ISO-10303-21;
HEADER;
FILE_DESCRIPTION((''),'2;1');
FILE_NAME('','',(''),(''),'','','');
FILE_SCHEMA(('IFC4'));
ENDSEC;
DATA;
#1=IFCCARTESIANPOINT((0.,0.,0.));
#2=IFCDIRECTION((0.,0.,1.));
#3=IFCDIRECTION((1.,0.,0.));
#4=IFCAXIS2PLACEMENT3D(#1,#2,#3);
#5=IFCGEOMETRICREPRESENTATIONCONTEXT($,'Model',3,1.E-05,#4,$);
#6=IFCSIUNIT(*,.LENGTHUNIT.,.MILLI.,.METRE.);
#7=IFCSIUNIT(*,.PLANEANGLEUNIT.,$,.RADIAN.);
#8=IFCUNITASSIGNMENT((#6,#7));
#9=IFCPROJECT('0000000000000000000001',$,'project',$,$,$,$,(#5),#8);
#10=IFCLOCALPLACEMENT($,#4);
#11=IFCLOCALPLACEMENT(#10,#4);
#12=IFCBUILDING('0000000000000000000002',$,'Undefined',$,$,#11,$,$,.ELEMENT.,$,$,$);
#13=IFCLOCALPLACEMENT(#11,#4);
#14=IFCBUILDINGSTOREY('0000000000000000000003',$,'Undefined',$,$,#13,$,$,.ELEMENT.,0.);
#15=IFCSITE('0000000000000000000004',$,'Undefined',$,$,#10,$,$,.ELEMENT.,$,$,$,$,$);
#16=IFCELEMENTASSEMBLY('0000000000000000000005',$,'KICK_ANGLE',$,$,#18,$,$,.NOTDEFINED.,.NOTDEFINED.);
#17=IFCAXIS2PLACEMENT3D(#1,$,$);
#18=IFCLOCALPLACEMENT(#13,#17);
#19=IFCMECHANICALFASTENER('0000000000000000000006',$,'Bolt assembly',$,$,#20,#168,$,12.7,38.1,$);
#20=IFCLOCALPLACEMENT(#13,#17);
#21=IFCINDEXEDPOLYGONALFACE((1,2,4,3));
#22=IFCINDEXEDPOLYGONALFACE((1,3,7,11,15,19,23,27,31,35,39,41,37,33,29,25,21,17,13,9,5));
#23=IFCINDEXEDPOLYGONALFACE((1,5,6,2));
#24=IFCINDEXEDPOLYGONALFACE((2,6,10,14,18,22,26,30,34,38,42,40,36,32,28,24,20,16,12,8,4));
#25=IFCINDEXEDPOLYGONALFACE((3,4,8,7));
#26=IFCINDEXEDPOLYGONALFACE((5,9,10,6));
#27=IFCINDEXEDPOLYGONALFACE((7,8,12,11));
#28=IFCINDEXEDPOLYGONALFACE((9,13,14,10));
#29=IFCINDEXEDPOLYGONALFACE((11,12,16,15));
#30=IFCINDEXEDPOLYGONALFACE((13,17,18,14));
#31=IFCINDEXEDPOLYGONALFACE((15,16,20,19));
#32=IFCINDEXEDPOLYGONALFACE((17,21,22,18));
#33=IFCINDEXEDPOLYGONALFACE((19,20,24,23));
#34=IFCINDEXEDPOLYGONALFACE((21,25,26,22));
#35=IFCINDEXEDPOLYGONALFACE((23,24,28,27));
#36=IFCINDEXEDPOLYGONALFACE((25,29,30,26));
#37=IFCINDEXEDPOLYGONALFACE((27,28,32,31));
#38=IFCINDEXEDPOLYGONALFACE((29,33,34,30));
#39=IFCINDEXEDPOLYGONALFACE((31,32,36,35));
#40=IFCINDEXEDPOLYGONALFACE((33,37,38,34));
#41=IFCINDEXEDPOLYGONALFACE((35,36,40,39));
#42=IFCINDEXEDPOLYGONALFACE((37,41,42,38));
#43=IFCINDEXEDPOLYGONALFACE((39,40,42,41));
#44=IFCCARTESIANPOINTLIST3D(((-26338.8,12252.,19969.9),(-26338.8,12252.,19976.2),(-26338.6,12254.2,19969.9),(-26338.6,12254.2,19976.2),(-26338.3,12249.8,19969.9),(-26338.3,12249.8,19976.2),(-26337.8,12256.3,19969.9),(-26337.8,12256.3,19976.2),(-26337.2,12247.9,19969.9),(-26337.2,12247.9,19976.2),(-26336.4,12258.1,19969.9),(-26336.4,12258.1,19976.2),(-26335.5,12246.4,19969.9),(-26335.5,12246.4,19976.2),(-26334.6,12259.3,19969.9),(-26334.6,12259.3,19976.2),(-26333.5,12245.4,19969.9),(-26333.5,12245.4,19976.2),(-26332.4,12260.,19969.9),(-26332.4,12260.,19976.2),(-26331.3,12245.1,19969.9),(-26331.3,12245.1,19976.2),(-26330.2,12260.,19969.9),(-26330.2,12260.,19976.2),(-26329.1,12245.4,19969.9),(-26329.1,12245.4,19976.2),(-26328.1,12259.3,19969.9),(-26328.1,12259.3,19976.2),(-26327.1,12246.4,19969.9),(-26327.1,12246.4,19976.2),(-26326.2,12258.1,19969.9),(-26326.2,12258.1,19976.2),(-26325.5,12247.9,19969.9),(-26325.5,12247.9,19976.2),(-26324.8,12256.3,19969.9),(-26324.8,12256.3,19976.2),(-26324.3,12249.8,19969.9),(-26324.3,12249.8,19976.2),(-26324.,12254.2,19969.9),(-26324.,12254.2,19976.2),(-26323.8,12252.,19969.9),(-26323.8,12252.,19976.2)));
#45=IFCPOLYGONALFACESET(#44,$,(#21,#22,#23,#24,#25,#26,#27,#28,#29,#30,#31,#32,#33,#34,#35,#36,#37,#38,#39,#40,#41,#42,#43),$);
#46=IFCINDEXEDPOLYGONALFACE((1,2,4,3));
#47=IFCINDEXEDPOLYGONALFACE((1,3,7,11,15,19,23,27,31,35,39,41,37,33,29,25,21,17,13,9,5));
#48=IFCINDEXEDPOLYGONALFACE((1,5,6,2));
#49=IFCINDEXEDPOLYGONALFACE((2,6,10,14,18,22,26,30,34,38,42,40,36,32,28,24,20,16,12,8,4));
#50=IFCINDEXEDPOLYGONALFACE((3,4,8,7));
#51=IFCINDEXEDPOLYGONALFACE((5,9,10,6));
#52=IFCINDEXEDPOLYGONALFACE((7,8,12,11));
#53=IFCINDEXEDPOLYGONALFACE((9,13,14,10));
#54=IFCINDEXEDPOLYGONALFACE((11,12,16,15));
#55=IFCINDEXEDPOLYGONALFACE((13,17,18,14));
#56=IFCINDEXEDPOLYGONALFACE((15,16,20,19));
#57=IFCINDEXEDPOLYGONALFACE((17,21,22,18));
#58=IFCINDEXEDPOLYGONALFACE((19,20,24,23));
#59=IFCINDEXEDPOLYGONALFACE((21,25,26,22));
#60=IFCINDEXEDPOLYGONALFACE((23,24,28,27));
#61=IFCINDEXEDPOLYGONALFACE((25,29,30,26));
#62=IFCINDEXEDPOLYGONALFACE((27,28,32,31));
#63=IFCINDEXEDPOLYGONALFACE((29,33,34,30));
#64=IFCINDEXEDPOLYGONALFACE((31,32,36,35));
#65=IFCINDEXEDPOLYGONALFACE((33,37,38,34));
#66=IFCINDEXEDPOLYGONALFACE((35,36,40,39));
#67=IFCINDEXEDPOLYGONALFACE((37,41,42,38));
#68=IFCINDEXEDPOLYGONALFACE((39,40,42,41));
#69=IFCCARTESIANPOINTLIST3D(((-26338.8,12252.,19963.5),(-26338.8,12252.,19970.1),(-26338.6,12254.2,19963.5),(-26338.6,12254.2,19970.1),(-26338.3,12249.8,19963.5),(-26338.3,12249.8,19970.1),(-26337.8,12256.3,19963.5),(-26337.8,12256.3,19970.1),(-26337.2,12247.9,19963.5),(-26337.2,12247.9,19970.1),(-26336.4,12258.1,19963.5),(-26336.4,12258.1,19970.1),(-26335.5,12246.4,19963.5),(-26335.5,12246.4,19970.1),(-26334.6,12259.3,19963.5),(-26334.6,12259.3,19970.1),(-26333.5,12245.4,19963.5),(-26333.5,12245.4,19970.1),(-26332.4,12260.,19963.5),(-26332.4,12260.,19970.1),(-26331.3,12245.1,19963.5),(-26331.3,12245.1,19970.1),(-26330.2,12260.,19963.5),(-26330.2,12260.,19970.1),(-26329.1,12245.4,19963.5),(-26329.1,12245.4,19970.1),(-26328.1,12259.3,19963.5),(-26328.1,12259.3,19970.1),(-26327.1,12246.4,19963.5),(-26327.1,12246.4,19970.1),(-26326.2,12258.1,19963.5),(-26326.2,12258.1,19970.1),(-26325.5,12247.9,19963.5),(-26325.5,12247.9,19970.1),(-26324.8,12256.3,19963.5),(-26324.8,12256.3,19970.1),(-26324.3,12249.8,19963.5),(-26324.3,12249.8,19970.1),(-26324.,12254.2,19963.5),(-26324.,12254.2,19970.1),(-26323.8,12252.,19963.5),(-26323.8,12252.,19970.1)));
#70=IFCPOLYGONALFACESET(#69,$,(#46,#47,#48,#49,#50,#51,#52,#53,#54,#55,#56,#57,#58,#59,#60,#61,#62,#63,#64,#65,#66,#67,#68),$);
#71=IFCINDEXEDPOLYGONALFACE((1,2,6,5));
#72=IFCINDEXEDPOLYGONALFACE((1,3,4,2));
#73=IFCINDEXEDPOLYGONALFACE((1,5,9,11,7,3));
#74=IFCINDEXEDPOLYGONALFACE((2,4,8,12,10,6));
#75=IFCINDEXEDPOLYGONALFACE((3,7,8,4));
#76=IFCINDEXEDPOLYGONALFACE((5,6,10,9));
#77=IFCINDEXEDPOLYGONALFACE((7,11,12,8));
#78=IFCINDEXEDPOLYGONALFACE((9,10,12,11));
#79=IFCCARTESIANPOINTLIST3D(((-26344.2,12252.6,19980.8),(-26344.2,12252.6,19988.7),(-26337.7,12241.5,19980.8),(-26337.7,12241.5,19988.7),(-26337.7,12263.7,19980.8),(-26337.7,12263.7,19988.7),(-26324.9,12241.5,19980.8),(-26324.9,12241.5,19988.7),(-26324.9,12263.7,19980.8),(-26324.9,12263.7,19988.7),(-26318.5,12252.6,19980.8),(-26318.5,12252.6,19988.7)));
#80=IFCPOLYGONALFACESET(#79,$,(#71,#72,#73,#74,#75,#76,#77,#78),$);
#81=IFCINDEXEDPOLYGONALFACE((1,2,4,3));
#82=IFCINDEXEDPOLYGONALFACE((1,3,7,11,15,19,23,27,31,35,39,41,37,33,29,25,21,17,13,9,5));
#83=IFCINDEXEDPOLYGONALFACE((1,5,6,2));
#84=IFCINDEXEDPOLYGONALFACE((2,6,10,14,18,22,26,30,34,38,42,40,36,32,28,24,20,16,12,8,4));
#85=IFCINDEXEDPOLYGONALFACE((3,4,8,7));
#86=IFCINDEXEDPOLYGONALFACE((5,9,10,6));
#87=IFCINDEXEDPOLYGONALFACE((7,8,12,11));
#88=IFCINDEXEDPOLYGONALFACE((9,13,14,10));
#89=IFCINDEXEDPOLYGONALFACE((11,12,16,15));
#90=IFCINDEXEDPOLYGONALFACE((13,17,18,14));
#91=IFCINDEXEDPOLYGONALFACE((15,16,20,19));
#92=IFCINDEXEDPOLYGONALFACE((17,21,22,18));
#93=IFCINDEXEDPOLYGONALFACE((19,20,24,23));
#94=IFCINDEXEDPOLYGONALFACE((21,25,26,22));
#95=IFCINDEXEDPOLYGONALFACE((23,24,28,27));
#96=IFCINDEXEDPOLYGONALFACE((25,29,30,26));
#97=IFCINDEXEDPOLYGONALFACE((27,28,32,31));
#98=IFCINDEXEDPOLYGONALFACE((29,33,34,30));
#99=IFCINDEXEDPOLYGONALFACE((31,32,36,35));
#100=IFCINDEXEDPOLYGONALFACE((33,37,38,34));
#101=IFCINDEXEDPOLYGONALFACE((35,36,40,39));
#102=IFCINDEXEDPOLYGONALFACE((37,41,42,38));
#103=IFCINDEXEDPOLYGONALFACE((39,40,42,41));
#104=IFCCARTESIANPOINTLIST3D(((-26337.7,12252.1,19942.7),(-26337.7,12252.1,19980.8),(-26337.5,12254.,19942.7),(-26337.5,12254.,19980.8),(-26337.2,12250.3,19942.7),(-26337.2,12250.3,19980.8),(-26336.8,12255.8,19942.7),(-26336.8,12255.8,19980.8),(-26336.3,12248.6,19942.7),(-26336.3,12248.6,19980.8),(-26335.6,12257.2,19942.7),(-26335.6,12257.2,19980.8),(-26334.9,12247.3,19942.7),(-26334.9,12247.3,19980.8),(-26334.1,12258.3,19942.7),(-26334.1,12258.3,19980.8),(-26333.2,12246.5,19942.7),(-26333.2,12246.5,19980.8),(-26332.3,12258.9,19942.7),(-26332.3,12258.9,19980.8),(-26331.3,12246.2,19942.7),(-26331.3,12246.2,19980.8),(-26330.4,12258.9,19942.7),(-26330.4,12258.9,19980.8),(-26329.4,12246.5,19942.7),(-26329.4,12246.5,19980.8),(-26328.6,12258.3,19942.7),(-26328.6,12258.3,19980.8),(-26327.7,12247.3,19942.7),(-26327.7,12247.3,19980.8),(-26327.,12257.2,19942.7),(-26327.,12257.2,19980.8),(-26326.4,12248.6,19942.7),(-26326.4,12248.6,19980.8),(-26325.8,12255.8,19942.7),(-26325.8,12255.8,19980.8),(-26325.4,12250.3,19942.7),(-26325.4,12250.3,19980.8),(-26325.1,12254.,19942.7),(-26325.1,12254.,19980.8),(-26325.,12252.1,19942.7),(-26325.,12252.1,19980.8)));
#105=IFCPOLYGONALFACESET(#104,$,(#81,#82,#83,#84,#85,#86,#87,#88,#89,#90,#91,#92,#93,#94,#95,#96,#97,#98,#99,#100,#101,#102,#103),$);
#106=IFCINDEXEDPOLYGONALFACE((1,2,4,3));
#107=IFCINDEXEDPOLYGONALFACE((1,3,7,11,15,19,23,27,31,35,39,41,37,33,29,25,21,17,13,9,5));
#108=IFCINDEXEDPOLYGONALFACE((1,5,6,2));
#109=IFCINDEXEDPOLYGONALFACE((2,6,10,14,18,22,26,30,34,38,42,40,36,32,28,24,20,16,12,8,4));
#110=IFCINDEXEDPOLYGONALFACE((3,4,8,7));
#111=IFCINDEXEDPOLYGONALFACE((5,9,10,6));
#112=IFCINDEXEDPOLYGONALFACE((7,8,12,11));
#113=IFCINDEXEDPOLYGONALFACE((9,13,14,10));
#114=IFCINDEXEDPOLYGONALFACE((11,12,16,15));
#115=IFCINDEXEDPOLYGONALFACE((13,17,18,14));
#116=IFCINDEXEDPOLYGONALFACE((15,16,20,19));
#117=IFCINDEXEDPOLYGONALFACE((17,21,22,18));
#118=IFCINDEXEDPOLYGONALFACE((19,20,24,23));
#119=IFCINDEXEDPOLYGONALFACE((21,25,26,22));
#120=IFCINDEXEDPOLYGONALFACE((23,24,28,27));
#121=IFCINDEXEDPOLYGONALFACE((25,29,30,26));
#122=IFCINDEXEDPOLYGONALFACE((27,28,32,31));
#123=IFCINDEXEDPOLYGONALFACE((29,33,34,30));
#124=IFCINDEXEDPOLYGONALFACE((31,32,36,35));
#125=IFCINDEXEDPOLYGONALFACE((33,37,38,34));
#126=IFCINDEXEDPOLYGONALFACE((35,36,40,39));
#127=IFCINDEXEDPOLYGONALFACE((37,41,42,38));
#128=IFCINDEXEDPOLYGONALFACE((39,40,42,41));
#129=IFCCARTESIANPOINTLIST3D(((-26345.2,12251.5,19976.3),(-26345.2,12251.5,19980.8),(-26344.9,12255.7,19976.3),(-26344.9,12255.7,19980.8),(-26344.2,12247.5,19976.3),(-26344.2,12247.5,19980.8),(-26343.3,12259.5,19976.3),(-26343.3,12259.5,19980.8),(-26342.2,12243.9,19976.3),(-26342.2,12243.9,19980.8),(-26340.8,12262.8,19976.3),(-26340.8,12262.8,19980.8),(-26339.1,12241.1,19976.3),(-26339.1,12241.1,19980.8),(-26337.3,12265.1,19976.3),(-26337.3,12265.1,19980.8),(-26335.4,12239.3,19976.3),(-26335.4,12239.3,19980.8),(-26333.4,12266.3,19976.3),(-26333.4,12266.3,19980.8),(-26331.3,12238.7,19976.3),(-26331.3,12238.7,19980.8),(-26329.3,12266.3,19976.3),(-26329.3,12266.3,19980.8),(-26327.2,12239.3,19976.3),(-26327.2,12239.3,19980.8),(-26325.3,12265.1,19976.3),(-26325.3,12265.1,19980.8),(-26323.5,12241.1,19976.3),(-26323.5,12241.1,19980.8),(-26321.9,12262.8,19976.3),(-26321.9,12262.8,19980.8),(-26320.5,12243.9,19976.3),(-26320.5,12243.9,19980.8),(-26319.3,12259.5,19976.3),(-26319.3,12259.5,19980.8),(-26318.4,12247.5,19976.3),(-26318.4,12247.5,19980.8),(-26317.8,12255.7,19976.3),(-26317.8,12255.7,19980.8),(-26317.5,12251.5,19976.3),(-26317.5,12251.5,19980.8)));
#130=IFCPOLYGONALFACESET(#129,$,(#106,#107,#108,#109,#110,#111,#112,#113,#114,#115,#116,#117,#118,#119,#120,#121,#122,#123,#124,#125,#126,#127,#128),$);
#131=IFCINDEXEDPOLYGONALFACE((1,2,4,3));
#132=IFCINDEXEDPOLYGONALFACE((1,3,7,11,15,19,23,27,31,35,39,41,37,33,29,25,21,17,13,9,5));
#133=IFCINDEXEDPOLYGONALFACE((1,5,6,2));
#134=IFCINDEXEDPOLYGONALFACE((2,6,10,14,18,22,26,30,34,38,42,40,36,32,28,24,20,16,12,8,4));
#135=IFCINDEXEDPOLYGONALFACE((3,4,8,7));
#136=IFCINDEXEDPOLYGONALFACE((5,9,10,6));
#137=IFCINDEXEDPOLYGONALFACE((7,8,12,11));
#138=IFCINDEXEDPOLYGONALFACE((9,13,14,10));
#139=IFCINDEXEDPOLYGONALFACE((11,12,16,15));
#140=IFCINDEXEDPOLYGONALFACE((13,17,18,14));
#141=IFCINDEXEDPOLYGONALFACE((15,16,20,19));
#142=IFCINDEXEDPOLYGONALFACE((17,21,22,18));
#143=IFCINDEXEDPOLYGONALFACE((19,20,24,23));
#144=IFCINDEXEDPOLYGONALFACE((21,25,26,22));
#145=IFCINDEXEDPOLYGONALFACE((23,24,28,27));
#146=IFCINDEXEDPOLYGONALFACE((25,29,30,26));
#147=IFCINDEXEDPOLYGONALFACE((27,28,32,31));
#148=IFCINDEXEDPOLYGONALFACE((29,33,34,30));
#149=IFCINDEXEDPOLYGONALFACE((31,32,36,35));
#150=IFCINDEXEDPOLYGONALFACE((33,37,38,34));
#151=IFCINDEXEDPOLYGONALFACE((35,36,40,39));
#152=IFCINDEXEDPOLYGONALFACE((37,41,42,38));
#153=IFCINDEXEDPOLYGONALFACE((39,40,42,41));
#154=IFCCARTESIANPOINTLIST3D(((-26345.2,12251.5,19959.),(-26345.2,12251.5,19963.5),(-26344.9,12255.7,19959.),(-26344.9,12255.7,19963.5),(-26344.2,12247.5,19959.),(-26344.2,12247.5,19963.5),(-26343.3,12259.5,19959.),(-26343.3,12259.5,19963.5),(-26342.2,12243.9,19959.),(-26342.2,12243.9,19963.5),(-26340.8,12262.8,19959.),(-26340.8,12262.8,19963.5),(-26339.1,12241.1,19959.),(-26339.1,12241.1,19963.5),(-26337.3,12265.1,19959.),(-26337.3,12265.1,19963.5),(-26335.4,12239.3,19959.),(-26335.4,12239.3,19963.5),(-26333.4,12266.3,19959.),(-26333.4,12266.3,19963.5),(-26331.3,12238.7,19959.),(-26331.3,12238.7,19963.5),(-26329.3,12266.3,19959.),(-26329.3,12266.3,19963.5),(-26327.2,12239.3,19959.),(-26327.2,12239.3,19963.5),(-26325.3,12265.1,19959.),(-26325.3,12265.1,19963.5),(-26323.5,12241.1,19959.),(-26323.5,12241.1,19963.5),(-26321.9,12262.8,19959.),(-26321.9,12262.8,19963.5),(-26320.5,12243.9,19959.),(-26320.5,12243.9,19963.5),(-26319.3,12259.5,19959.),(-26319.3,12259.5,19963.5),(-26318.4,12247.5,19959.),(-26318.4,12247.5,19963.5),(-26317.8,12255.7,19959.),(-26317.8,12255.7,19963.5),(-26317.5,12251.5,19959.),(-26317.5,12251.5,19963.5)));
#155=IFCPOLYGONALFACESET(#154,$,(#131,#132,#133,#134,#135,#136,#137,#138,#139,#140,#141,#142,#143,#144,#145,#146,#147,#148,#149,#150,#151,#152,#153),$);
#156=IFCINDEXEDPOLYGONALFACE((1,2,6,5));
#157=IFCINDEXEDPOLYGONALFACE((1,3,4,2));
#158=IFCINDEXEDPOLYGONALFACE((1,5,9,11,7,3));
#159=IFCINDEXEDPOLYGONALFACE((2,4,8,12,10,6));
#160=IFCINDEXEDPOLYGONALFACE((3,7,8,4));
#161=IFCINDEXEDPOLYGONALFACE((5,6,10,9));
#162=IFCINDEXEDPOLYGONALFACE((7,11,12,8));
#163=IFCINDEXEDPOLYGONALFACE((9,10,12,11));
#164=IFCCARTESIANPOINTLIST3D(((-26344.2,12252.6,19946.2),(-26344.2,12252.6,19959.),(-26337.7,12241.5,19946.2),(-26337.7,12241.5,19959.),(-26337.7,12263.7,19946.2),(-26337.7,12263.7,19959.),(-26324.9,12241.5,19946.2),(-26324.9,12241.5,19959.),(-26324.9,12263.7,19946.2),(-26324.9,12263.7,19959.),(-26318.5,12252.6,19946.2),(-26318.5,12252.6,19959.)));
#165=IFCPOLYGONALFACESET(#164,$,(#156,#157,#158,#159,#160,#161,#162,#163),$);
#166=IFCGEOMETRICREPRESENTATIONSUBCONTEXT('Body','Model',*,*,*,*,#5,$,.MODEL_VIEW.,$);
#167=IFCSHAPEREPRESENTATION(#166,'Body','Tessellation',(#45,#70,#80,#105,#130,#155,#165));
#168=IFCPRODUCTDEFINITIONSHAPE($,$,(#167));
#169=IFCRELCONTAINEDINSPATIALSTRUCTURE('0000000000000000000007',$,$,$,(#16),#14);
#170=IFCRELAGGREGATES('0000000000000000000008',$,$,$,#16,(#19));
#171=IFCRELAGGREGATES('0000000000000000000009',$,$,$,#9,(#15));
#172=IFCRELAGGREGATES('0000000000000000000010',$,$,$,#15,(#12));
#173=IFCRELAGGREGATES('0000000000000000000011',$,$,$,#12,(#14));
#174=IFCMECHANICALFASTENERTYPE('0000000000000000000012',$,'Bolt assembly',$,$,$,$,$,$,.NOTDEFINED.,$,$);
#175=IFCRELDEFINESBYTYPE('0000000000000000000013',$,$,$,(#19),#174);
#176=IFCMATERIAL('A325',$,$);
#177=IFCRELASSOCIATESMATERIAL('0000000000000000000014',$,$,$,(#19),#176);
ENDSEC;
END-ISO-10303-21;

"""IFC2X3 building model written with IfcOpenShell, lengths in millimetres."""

from ifc_helpers import new_model, si_unit, frame, origin_with_axes, origin_2d_with_axis, place, context, subcontext, project, spatial, polyline, circle, outline, extrude, source, transform, mapped, material, type_object, element, aggregate, save


model = new_model("IFC2X3")

# Units and contexts
model_context = context("Model", 3, precision=1e-05, world=origin_with_axes())
body_context = subcontext(model_context, "Body", "Model", "MODEL_VIEW")
ifc_project = project(units=[si_unit("LENGTHUNIT", "METRE", prefix="MILLI"), si_unit("PLANEANGLEUNIT", "RADIAN")], contexts=[model_context])

# Site, building, storey
site_placement = place(None, origin_with_axes())
site = spatial("IfcSite", under=ifc_project, at=site_placement, Name="Undefined", CompositionType="ELEMENT")
building_placement = place(site_placement, origin_with_axes())
building = spatial("IfcBuilding", under=site, at=building_placement, Name="Undefined", CompositionType="ELEMENT")
storey_placement = place(building_placement, origin_with_axes())
storey = spatial("IfcBuildingStorey", under=building, at=storey_placement, Name="Undefined", CompositionType="ELEMENT", Elevation=0.0)

# Element assembly
assembly_1_placement = place(storey_placement, origin_with_axes())
assembly_1 = element("IfcElementAssembly", 1, at=assembly_1_placement, inside=storey, Name="KICK_ANGLE", AssemblyPlace="NOTDEFINED", PredefinedType="NOTDEFINED")

# Shared definitions
ifc_material_1 = material(Name="A325")
mechanical_fastener_type = type_object("IfcMechanicalFastenerType", Name="Bolt assembly")

# Mechanical fastener
shared_shape_1 = source(origin_with_axes(), body_context, "Body", "SweptSolid", [
    extrude(circle(Radius=7.5, at=origin_2d_with_axis()), frame((0.0, -6.2, 0.0), z_axis=(0.0, 1.0, 0.0), x_axis=(1.0, 0.0, 0.0)), (0.0, 0.0, 1.0), 6.3),
    extrude(circle(Radius=7.5, at=origin_2d_with_axis()), frame((0.0, -0.1, 0.0), z_axis=(0.0, 1.0, 0.0), x_axis=(1.0, 0.0, 0.0)), (0.0, 0.0, 1.0), 6.6),
    extrude(outline(polyline([(11.1, -6.4), (11.1, 6.4), (0.0, 12.8), (-11.1, 6.4), (-11.1, -6.4), (0.0, -12.8), (11.1, -6.4)])), frame((0.0, -18.7, 0.0), z_axis=(0.0, 1.0, 0.0), x_axis=(1.0, 0.0, 0.0)), (0.0, 0.0, 1.0), 7.9),
    extrude(circle(Radius=6.3, at=origin_2d_with_axis()), frame((0.0, -10.8, 0.0), z_axis=(0.0, 1.0, 0.0), x_axis=(1.0, 0.0, 0.0)), (0.0, 0.0, 1.0), 38.1),
    extrude(circle(Radius=13.9, at=origin_2d_with_axis()), frame((0.0, -10.8, 0.0), z_axis=(0.0, 1.0, 0.0), x_axis=(1.0, 0.0, 0.0)), (0.0, 0.0, 1.0), 4.5),
    extrude(circle(Radius=13.9, at=origin_2d_with_axis()), frame((0.0, 6.5, 0.0), z_axis=(0.0, 1.0, 0.0), x_axis=(1.0, 0.0, 0.0)), (0.0, 0.0, 1.0), 4.5),
    extrude(outline(polyline([(11.1, -6.4), (11.1, 6.4), (0.0, 12.8), (-11.1, 6.4), (-11.1, -6.4), (0.0, -12.8), (11.1, -6.4)])), frame((0.0, 11.0, 0.0), z_axis=(0.0, 1.0, 0.0), x_axis=(1.0, 0.0, 0.0)), (0.0, 0.0, 1.0), 12.8),
])
mechanical_fastener_1_placement = place(assembly_1_placement, frame((-26331.3, 12280.1, 19970.0), z_axis=(1.0, 0.0, 0.0), x_axis=(0.0, -1.0, 0.0)))
mechanical_fastener_1 = element("IfcMechanicalFastener", 2, at=mechanical_fastener_1_placement, type_object=mechanical_fastener_type, material=ifc_material_1, Name="Bolt assembly", NominalDiameter=12.7, NominalLength=38.1, context=body_context, shape_type="MappedRepresentation", body=[
    mapped(shared_shape_1, transform((27.5, 0.0, 0.0))),
])
aggregate(assembly_1, [mechanical_fastener_1])

save(model, "model.ifc")
